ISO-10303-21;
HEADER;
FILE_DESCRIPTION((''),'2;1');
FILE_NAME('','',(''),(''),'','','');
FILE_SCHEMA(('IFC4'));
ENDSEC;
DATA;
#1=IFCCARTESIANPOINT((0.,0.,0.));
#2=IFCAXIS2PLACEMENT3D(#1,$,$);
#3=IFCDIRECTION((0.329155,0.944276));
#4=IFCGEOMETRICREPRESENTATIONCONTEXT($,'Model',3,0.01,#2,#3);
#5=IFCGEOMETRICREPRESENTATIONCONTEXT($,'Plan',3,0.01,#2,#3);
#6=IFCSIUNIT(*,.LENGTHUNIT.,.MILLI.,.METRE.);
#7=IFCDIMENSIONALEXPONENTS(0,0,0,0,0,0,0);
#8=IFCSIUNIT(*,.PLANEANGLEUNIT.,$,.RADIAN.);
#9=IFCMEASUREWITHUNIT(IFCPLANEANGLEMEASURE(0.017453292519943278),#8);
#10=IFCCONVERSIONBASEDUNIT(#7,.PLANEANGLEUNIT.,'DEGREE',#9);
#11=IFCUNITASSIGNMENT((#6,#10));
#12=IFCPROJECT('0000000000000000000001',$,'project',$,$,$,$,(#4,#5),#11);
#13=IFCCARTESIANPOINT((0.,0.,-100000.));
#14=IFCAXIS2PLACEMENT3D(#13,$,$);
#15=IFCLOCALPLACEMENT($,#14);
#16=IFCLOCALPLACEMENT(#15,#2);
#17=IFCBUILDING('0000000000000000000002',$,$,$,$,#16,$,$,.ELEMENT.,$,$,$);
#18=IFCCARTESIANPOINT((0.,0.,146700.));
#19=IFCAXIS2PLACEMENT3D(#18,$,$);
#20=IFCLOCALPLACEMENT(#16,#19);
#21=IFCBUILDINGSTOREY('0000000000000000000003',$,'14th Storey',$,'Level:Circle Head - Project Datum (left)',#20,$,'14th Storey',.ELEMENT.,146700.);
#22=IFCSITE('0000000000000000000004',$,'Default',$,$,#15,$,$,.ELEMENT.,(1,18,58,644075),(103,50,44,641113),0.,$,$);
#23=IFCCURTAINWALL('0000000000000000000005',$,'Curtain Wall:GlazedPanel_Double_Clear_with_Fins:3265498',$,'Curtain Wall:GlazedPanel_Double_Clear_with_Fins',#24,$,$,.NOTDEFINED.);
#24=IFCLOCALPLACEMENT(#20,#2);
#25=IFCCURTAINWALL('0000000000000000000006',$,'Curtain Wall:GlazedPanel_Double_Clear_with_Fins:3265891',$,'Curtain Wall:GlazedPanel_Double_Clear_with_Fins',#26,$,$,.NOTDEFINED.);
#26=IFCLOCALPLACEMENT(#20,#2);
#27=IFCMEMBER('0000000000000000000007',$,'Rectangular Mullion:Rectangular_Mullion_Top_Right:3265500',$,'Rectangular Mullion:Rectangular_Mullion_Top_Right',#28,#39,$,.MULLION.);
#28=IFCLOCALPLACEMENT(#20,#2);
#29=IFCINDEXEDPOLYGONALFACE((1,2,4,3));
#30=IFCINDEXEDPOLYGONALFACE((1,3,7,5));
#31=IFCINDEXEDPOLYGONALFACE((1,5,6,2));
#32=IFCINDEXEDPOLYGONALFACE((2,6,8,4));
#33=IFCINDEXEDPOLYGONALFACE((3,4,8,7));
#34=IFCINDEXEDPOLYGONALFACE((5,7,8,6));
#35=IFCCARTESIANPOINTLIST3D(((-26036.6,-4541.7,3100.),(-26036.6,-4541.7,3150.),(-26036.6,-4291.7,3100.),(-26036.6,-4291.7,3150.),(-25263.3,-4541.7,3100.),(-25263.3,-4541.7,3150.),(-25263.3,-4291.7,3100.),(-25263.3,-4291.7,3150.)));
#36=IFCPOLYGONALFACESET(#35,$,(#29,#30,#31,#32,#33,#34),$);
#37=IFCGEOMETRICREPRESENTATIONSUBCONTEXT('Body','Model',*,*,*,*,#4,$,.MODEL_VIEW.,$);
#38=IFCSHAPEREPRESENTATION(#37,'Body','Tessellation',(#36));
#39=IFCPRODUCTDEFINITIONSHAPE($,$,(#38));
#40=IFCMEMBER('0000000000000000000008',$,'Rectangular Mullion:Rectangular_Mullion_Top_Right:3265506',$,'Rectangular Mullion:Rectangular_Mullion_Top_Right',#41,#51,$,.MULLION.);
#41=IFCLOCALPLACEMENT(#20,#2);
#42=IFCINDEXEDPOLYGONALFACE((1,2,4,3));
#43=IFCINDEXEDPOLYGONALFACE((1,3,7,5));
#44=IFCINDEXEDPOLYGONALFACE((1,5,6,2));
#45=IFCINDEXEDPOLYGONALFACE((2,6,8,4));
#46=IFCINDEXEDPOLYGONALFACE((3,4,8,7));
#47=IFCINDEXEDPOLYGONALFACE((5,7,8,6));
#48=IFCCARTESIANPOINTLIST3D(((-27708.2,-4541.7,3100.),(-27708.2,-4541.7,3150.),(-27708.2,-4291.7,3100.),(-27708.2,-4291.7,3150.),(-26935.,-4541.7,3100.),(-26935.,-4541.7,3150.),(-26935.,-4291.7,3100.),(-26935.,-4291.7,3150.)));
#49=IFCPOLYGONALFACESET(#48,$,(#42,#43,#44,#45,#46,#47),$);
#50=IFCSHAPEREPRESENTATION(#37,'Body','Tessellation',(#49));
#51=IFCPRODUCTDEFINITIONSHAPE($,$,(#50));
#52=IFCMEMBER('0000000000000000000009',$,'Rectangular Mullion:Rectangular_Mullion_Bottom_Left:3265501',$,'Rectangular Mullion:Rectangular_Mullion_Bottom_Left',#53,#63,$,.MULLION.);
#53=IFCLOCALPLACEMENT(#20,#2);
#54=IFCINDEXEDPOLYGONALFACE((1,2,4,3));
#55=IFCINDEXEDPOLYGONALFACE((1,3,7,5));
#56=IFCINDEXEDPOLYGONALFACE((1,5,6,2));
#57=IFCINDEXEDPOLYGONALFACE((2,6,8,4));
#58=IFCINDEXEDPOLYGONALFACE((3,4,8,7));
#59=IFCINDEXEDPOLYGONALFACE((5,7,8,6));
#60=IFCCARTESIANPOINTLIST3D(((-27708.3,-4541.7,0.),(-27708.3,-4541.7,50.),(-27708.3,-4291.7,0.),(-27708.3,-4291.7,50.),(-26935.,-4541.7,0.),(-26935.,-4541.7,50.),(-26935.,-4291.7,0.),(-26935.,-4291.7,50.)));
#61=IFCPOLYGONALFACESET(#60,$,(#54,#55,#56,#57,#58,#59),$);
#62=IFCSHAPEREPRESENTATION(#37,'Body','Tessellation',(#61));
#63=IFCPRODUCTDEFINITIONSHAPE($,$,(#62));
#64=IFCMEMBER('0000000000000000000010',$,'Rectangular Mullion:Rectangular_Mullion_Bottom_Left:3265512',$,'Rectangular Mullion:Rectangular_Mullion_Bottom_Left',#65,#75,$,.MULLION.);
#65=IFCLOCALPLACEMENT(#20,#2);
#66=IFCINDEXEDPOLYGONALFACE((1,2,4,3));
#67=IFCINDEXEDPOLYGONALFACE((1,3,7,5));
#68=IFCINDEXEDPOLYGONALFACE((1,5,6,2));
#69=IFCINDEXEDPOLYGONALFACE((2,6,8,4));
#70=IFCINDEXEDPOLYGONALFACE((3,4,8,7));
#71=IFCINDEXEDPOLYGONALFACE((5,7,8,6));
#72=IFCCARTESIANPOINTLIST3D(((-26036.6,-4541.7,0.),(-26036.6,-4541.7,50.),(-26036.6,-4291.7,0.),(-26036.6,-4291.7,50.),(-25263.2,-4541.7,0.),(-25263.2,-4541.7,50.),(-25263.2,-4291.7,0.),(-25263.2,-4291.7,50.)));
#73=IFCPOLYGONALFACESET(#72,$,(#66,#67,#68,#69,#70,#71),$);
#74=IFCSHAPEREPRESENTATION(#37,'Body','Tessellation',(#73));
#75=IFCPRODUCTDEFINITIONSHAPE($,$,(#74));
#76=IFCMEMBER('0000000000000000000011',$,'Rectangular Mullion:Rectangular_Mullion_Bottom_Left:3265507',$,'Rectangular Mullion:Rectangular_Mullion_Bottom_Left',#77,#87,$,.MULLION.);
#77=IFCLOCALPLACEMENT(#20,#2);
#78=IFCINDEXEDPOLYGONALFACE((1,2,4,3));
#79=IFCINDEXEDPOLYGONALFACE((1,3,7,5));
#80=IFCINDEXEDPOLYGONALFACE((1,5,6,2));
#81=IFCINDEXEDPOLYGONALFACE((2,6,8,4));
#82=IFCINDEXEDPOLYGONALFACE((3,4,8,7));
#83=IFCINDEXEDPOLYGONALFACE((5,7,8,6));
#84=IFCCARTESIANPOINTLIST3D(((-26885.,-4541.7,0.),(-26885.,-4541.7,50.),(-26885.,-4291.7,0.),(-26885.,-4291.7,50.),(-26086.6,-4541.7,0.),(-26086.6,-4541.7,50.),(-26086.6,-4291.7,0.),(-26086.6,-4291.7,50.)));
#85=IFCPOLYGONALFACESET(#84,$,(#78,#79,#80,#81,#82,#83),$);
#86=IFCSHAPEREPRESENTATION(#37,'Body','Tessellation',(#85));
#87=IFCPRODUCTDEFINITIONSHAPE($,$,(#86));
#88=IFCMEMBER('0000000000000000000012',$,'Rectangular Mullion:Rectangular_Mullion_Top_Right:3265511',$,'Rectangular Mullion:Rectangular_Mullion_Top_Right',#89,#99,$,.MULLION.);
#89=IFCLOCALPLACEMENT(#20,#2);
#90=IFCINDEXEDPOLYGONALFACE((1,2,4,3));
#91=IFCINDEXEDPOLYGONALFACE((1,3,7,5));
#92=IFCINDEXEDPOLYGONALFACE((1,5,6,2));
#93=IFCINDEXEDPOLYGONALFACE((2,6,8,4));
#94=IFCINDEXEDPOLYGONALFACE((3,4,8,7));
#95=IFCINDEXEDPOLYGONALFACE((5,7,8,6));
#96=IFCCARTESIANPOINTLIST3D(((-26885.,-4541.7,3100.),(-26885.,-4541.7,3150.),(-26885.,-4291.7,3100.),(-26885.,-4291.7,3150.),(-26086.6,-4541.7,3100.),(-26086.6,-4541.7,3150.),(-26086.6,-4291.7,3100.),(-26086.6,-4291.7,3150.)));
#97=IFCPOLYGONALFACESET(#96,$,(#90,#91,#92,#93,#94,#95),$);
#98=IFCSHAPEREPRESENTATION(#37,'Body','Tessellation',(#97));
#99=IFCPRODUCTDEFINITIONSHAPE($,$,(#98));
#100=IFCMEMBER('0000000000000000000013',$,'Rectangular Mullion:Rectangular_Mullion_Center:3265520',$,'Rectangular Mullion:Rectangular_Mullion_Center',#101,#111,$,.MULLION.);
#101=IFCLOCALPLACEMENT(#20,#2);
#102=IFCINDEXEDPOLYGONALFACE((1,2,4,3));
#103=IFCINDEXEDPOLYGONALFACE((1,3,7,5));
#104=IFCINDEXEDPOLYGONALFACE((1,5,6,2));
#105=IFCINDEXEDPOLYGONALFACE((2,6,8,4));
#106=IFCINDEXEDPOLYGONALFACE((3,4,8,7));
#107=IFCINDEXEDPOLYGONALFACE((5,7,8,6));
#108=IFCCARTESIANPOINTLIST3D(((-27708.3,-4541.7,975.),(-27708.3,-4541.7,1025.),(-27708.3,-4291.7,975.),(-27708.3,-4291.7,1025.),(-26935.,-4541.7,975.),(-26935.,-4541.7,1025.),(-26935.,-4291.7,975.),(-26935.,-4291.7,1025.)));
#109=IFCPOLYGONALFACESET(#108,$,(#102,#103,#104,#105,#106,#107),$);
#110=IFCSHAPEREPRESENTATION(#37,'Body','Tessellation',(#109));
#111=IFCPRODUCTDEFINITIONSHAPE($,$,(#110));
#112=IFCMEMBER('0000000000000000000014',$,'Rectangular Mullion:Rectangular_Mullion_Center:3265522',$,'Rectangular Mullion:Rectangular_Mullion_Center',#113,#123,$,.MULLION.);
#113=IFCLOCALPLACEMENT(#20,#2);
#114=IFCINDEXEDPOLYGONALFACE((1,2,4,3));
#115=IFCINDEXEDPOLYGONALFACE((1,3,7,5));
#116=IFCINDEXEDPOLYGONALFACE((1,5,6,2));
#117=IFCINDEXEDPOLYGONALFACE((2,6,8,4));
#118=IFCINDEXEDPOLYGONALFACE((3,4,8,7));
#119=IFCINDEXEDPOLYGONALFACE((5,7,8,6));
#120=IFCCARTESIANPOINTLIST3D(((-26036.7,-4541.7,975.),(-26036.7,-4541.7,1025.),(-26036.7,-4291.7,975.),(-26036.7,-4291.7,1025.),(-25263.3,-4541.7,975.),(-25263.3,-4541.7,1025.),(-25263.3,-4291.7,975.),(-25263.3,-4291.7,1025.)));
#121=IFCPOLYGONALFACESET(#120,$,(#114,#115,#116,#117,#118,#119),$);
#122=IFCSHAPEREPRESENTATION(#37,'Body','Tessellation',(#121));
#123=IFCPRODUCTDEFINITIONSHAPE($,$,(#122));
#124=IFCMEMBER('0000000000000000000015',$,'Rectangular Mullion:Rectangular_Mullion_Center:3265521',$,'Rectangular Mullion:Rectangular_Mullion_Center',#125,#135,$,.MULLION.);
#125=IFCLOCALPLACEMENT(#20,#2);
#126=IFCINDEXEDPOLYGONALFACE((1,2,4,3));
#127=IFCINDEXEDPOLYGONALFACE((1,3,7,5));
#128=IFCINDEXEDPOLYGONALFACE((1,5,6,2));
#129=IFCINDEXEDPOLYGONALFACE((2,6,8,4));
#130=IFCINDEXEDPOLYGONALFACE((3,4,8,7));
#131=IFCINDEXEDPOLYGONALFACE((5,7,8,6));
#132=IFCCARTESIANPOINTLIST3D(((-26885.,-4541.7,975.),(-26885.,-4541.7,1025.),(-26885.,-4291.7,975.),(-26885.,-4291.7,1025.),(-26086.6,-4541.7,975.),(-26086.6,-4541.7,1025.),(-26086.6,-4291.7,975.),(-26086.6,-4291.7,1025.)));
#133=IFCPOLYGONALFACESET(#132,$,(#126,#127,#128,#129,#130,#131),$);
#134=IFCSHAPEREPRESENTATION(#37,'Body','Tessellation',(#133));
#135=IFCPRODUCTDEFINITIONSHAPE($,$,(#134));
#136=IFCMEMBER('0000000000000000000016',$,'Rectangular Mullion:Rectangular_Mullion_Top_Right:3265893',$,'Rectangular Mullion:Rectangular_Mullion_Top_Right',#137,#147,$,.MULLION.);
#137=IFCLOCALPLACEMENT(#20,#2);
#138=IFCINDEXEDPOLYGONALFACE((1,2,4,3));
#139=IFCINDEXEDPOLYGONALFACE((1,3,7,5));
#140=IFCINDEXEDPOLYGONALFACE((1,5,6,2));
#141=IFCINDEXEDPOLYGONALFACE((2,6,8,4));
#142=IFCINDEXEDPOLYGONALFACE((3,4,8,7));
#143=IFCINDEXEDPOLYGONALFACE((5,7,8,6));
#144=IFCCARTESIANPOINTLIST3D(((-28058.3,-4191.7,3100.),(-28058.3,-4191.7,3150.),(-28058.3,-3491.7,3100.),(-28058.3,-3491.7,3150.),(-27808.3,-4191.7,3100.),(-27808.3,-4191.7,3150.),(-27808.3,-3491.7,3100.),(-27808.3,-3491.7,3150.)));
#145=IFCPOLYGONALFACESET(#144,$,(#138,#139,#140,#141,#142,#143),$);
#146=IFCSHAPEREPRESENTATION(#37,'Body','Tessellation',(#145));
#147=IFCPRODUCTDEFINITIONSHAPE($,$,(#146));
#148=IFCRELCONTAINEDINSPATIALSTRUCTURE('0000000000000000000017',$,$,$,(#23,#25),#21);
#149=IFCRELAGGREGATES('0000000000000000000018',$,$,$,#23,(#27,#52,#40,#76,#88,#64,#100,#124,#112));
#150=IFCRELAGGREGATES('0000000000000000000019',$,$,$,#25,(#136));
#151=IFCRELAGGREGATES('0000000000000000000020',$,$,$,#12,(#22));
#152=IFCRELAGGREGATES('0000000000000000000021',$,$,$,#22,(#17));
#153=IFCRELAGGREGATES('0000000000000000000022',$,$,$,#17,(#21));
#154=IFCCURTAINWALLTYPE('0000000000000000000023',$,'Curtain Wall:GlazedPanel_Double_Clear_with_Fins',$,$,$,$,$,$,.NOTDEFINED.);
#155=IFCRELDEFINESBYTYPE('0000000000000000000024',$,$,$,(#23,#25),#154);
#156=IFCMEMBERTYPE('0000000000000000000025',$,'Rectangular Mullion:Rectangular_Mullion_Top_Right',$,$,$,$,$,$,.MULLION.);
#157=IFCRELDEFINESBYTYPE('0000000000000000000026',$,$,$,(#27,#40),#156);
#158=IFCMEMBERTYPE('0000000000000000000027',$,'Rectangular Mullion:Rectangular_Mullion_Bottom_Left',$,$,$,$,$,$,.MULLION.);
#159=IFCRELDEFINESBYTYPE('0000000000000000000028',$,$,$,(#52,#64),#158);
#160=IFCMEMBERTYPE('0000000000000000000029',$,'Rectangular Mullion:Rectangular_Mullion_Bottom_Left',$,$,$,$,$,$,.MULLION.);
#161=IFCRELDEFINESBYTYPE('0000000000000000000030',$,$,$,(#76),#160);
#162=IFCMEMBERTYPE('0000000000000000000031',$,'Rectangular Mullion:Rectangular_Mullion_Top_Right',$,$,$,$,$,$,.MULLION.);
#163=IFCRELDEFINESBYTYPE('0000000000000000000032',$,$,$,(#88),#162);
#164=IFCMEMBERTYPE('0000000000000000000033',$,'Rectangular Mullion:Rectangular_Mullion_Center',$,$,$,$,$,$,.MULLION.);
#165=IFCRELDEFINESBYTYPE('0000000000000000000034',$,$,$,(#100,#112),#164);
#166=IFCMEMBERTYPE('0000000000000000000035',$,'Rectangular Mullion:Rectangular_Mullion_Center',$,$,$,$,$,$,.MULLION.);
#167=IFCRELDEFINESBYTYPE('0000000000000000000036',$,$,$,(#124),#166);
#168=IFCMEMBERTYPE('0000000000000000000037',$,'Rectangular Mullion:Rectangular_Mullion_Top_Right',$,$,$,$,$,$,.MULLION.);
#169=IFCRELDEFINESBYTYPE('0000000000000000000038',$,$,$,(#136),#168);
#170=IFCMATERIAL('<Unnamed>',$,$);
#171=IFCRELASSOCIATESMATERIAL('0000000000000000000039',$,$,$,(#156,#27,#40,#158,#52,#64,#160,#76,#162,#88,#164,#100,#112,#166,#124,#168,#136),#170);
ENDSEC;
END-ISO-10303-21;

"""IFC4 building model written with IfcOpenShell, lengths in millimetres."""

from ifc_helpers import new_model, entity, si_unit, converted_unit, direction, frame, origin, place, context, subcontext, project, spatial, indexed_curve, outline, extrude, source, transform, mapped, material, type_object, type_shapes, element, aggregate, save


model = new_model("IFC4")

# Units and contexts
model_context = context("Model", 3, precision=0.01, world=origin(), true_north=direction((0.329155, 0.944276)))
plan_context = context("Plan", 3, precision=0.01, world=origin(), true_north=direction((0.329155, 0.944276)))
body_context = subcontext(model_context, "Body", "Model", "MODEL_VIEW")
ifc_project = project(units=[si_unit("LENGTHUNIT", "METRE", prefix="MILLI"), converted_unit("PLANEANGLEUNIT", "DEGREE", entity("IfcPlaneAngleMeasure", 0.017453292519943278), si_unit("PLANEANGLEUNIT", "RADIAN"), dimensions=[0, 0, 0, 0, 0, 0, 0])], contexts=[model_context, plan_context])

# Site, building, storey
site_placement = place(None, frame((0.0, 0.0, -100000.0)))
site = spatial("IfcSite", under=ifc_project, at=site_placement, Name="Default", CompositionType="ELEMENT", RefLatitude=(1, 18, 58, 644075), RefLongitude=(103, 50, 44, 641113), RefElevation=0.0)
building_placement = place(site_placement, origin())
building = spatial("IfcBuilding", under=site, at=building_placement, CompositionType="ELEMENT")
storey_placement = place(building_placement, frame((0.0, 0.0, 146700.0)))
storey = spatial("IfcBuildingStorey", under=building, at=storey_placement, Name="14th Storey", ObjectType="Level:Circle Head - Project Datum (left)", LongName="14th Storey", CompositionType="ELEMENT", Elevation=146700.0)

# Curtain walls
curtain_wall_type = type_object("IfcCurtainWallType", Name="Curtain Wall:GlazedPanel_Double_Clear_with_Fins", PredefinedType="NOTDEFINED")
curtain_wall_1_placement = place(storey_placement, frame((0.0, 0.0, -146700.0)))
curtain_wall_1 = element("IfcCurtainWall", 1, at=curtain_wall_1_placement, inside=storey, type_object=curtain_wall_type, Name="Curtain Wall:GlazedPanel_Double_Clear_with_Fins:3265498", ObjectType="Curtain Wall:GlazedPanel_Double_Clear_with_Fins", PredefinedType="NOTDEFINED")
ifc_material_1 = material(Name="<Unnamed>")
curtain_wall_2_placement = place(storey_placement, frame((0.0, 0.0, -146700.0)))
curtain_wall_2 = element("IfcCurtainWall", 2, at=curtain_wall_2_placement, inside=storey, type_object=curtain_wall_type, Name="Curtain Wall:GlazedPanel_Double_Clear_with_Fins:3265891", ObjectType="Curtain Wall:GlazedPanel_Double_Clear_with_Fins", PredefinedType="NOTDEFINED")

# Members
member_type_1 = type_object("IfcMemberType", Name="Rectangular Mullion:Rectangular_Mullion_Top_Right", PredefinedType="MULLION", material=ifc_material_1)
shared_shape_1 = source(origin(), body_context, "Body", "SweptSolid", [
    extrude(outline(indexed_curve([(-25.0, -125.0), (25.0, -125.0), (25.0, 125.0), (-25.0, 125.0), (-25.0, -125.0)], self_intersect=False)), frame((-25.0, 0.0, -773.3), z_axis=(0.0, 0.0, 1.0), x_axis=(-1.0, 0.0, 0.0)), (0.0, 0.0, 1.0), 773.3),
])
type_shapes(member_type_1, [shared_shape_1])
member_1_placement = place(curtain_wall_1_placement, frame((-25263.3, -4416.7, 149850.0), z_axis=(1.0, 0.0, 0.0), x_axis=(0.0, 0.0, 1.0)))
member_1 = element("IfcMember", 3, at=member_1_placement, type_object=member_type_1, material=ifc_material_1, Name="Rectangular Mullion:Rectangular_Mullion_Top_Right:3265500", ObjectType="Rectangular Mullion:Rectangular_Mullion_Top_Right", PredefinedType="MULLION", context=body_context, shape_type="MappedRepresentation", body=[
    mapped(shared_shape_1, transform((0.0, 0.0, 0.0), scale=1.0)),
])
member_2_placement = place(curtain_wall_1_placement, frame((-26935.0, -4416.7, 149850.0), z_axis=(1.0, 0.0, 0.0), x_axis=(0.0, 0.0, 1.0)))
member_2 = element("IfcMember", 4, at=member_2_placement, type_object=member_type_1, material=ifc_material_1, Name="Rectangular Mullion:Rectangular_Mullion_Top_Right:3265506", ObjectType="Rectangular Mullion:Rectangular_Mullion_Top_Right", PredefinedType="MULLION", context=body_context, shape_type="MappedRepresentation", body=[
    mapped(shared_shape_1, transform((0.0, 0.0, 0.0), scale=1.0)),
])
member_type_2 = type_object("IfcMemberType", Name="Rectangular Mullion:Rectangular_Mullion_Bottom_Left", PredefinedType="MULLION", material=ifc_material_1)
shared_shape_2 = source(origin(), body_context, "Body", "SweptSolid", [
    extrude(outline(indexed_curve([(-25.0, -125.0), (25.0, -125.0), (25.0, 125.0), (-25.0, 125.0), (-25.0, -125.0)], self_intersect=False)), frame((-25.0, 0.0, -773.4), z_axis=(0.0, 0.0, 1.0), x_axis=(-1.0, 0.0, 0.0)), (0.0, 0.0, 1.0), 773.4),
])
type_shapes(member_type_2, [shared_shape_2])
member_3_placement = place(curtain_wall_1_placement, frame((-27708.3, -4416.7, 146700.0), z_axis=(-1.0, 0.0, 0.0), x_axis=(0.0, 0.0, -1.0)))
member_3 = element("IfcMember", 5, at=member_3_placement, type_object=member_type_2, material=ifc_material_1, Name="Rectangular Mullion:Rectangular_Mullion_Bottom_Left:3265501", ObjectType="Rectangular Mullion:Rectangular_Mullion_Bottom_Left", PredefinedType="MULLION", context=body_context, shape_type="MappedRepresentation", body=[
    mapped(shared_shape_2, transform((0.0, 0.0, 0.0), scale=1.0)),
])
member_4_placement = place(curtain_wall_1_placement, frame((-26036.6, -4416.7, 146700.0), z_axis=(-1.0, 0.0, 0.0), x_axis=(0.0, 0.0, -1.0)))
member_4 = element("IfcMember", 6, at=member_4_placement, type_object=member_type_2, material=ifc_material_1, Name="Rectangular Mullion:Rectangular_Mullion_Bottom_Left:3265512", ObjectType="Rectangular Mullion:Rectangular_Mullion_Bottom_Left", PredefinedType="MULLION", context=body_context, shape_type="MappedRepresentation", body=[
    mapped(shared_shape_2, transform((0.0, 0.0, 0.0), scale=1.0)),
])
member_type_3 = type_object("IfcMemberType", Name="Rectangular Mullion:Rectangular_Mullion_Bottom_Left", PredefinedType="MULLION", material=ifc_material_1)
shared_shape_3 = source(origin(), body_context, "Body", "SweptSolid", [
    extrude(outline(indexed_curve([(-25.0, -125.0), (25.0, -125.0), (25.0, 125.0), (-25.0, 125.0), (-25.0, -125.0)], self_intersect=False)), frame((-25.0, 0.0, -798.4), z_axis=(0.0, 0.0, 1.0), x_axis=(-1.0, 0.0, 0.0)), (0.0, 0.0, 1.0), 798.4),
])
type_shapes(member_type_3, [shared_shape_3])
member_5_placement = place(curtain_wall_1_placement, frame((-26885.0, -4416.7, 146700.0), z_axis=(-1.0, 0.0, 0.0), x_axis=(0.0, 0.0, -1.0)))
member_5 = element("IfcMember", 7, at=member_5_placement, type_object=member_type_3, material=ifc_material_1, Name="Rectangular Mullion:Rectangular_Mullion_Bottom_Left:3265507", ObjectType="Rectangular Mullion:Rectangular_Mullion_Bottom_Left", PredefinedType="MULLION", context=body_context, shape_type="MappedRepresentation", body=[
    mapped(shared_shape_3, transform((0.0, 0.0, 0.0), scale=1.0)),
])
member_type_4 = type_object("IfcMemberType", Name="Rectangular Mullion:Rectangular_Mullion_Top_Right", PredefinedType="MULLION", material=ifc_material_1)
shared_shape_4 = source(origin(), body_context, "Body", "SweptSolid", [
    extrude(outline(indexed_curve([(-25.0, -125.0), (25.0, -125.0), (25.0, 125.0), (-25.0, 125.0), (-25.0, -125.0)], self_intersect=False)), frame((-25.0, 0.0, -798.4), z_axis=(0.0, 0.0, 1.0), x_axis=(-1.0, 0.0, 0.0)), (0.0, 0.0, 1.0), 798.4),
])
type_shapes(member_type_4, [shared_shape_4])
member_6_placement = place(curtain_wall_1_placement, frame((-26086.6, -4416.7, 149850.0), z_axis=(1.0, 0.0, 0.0), x_axis=(0.0, 0.0, 1.0)))
member_6 = element("IfcMember", 8, at=member_6_placement, type_object=member_type_4, material=ifc_material_1, Name="Rectangular Mullion:Rectangular_Mullion_Top_Right:3265511", ObjectType="Rectangular Mullion:Rectangular_Mullion_Top_Right", PredefinedType="MULLION", context=body_context, shape_type="MappedRepresentation", body=[
    mapped(shared_shape_4, transform((0.0, 0.0, 0.0), scale=1.0)),
])
member_type_5 = type_object("IfcMemberType", Name="Rectangular Mullion:Rectangular_Mullion_Center", PredefinedType="MULLION", material=ifc_material_1)
shared_shape_5 = source(origin(), body_context, "Body", "SweptSolid", [
    extrude(outline(indexed_curve([(-25.0, -125.0), (25.0, -125.0), (25.0, 125.0), (-25.0, 125.0), (-25.0, -125.0)], self_intersect=False)), frame((0.0, 0.0, -773.4), z_axis=(0.0, 0.0, 1.0), x_axis=(-1.0, 0.0, 0.0)), (0.0, 0.0, 1.0), 773.4),
])
type_shapes(member_type_5, [shared_shape_5])
member_7_placement = place(curtain_wall_1_placement, frame((-26935.0, -4416.7, 147700.0), z_axis=(1.0, 0.0, 0.0), x_axis=(0.0, 0.0, 1.0)))
member_7 = element("IfcMember", 9, at=member_7_placement, type_object=member_type_5, material=ifc_material_1, Name="Rectangular Mullion:Rectangular_Mullion_Center:3265520", ObjectType="Rectangular Mullion:Rectangular_Mullion_Center", PredefinedType="MULLION", context=body_context, shape_type="MappedRepresentation", body=[
    mapped(shared_shape_5, transform((0.0, 0.0, 0.0), scale=1.0)),
])
member_8_placement = place(curtain_wall_1_placement, frame((-25263.3, -4416.7, 147700.0), z_axis=(1.0, 0.0, 0.0), x_axis=(0.0, 0.0, 1.0)))
member_8 = element("IfcMember", 10, at=member_8_placement, type_object=member_type_5, material=ifc_material_1, Name="Rectangular Mullion:Rectangular_Mullion_Center:3265522", ObjectType="Rectangular Mullion:Rectangular_Mullion_Center", PredefinedType="MULLION", context=body_context, shape_type="MappedRepresentation", body=[
    mapped(shared_shape_5, transform((0.0, 0.0, 0.0), scale=1.0)),
])
member_type_6 = type_object("IfcMemberType", Name="Rectangular Mullion:Rectangular_Mullion_Center", PredefinedType="MULLION", material=ifc_material_1)
shared_shape_6 = source(origin(), body_context, "Body", "SweptSolid", [
    extrude(outline(indexed_curve([(-25.0, -125.0), (25.0, -125.0), (25.0, 125.0), (-25.0, 125.0), (-25.0, -125.0)], self_intersect=False)), frame((0.0, 0.0, -798.4), z_axis=(0.0, 0.0, 1.0), x_axis=(-1.0, 0.0, 0.0)), (0.0, 0.0, 1.0), 798.4),
])
type_shapes(member_type_6, [shared_shape_6])
member_9_placement = place(curtain_wall_1_placement, frame((-26086.6, -4416.7, 147700.0), z_axis=(1.0, 0.0, 0.0), x_axis=(0.0, 0.0, 1.0)))
member_9 = element("IfcMember", 11, at=member_9_placement, type_object=member_type_6, material=ifc_material_1, Name="Rectangular Mullion:Rectangular_Mullion_Center:3265521", ObjectType="Rectangular Mullion:Rectangular_Mullion_Center", PredefinedType="MULLION", context=body_context, shape_type="MappedRepresentation", body=[
    mapped(shared_shape_6, transform((0.0, 0.0, 0.0), scale=1.0)),
])
member_type_7 = type_object("IfcMemberType", Name="Rectangular Mullion:Rectangular_Mullion_Top_Right", PredefinedType="MULLION", material=ifc_material_1)
shared_shape_7 = source(origin(), body_context, "Body", "SweptSolid", [
    extrude(outline(indexed_curve([(-25.0, -125.0), (25.0, -125.0), (25.0, 125.0), (-25.0, 125.0), (-25.0, -125.0)], self_intersect=False)), frame((-25.0, 0.0, -700.0), z_axis=(0.0, 0.0, 1.0), x_axis=(-1.0, 0.0, 0.0)), (0.0, 0.0, 1.0), 700.0),
])
type_shapes(member_type_7, [shared_shape_7])
member_10_placement = place(curtain_wall_2_placement, frame((-27933.3, -4191.7, 149850.0), z_axis=(0.0, -1.0, 0.0), x_axis=(0.0, 0.0, 1.0)))
member_10 = element("IfcMember", 12, at=member_10_placement, type_object=member_type_7, material=ifc_material_1, Name="Rectangular Mullion:Rectangular_Mullion_Top_Right:3265893", ObjectType="Rectangular Mullion:Rectangular_Mullion_Top_Right", PredefinedType="MULLION", context=body_context, shape_type="MappedRepresentation", body=[
    mapped(shared_shape_7, transform((0.0, 0.0, 0.0), scale=1.0)),
])

aggregate(curtain_wall_1, [member_1, member_3, member_2, member_5, member_6, member_4, member_7, member_9, member_8])
aggregate(curtain_wall_2, [member_10])

save(model, "model.ifc")
